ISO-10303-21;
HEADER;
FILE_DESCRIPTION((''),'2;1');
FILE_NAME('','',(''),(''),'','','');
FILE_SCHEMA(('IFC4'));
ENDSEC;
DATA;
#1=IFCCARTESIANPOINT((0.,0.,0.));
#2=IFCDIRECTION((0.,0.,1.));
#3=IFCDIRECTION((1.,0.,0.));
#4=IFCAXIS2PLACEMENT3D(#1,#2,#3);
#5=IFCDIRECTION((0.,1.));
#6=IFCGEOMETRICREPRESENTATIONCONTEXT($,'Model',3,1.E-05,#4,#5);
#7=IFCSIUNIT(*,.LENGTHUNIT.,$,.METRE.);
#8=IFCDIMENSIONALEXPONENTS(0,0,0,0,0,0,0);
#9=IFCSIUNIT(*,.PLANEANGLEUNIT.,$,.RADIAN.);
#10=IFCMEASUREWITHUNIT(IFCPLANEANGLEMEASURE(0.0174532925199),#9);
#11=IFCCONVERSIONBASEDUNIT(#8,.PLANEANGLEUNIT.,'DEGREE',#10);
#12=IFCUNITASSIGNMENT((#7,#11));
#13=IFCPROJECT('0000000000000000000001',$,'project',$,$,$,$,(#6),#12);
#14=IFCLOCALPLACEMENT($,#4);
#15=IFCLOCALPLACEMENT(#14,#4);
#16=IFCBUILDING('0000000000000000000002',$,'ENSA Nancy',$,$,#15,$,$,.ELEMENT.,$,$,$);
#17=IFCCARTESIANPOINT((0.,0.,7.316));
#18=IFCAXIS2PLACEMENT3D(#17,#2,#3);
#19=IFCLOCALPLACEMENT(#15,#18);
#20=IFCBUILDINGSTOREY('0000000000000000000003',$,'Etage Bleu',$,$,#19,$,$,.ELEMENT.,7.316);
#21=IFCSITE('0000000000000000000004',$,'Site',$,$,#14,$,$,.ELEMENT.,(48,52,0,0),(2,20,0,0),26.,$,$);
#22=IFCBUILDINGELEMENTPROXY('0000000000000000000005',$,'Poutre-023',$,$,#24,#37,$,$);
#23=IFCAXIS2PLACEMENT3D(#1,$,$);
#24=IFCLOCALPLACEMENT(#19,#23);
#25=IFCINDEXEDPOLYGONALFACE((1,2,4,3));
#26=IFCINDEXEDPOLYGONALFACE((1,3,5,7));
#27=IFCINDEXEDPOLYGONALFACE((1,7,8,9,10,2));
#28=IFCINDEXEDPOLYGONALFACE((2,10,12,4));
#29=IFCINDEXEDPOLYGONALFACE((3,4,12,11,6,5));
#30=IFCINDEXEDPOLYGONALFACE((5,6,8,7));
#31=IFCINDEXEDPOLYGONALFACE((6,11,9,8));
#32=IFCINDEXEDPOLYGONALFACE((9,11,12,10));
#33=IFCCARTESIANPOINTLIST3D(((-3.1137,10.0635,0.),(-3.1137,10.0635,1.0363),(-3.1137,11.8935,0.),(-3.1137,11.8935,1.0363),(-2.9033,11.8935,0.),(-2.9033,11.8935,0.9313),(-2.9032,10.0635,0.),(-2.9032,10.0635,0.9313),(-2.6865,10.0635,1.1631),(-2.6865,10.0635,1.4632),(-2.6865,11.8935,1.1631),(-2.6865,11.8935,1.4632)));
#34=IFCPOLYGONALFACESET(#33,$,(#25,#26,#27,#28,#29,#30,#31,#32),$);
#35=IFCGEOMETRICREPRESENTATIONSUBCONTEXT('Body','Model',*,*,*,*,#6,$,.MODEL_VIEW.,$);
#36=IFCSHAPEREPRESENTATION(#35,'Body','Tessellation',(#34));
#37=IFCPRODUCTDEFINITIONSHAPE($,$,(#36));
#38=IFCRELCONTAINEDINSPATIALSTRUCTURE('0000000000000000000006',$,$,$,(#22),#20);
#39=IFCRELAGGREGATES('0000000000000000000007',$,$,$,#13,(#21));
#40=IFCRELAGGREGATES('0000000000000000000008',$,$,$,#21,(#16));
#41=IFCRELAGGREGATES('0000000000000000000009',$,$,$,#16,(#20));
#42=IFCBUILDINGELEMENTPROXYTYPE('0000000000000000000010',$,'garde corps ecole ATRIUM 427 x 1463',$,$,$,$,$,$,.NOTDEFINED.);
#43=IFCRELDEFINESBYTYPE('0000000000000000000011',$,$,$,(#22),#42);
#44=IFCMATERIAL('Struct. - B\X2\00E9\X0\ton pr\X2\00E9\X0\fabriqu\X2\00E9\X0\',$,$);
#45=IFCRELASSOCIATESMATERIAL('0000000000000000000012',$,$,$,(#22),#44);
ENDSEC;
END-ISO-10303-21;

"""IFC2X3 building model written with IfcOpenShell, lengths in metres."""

from ifc_helpers import new_model, entity, si_unit, converted_unit, direction, frame, origin_with_axes, place, context, subcontext, project, spatial, polyline, outline, extrude, material, type_object, element, save


model = new_model("IFC2X3")

# Units and contexts
model_context = context("Model", 3, precision=1e-05, world=origin_with_axes(), true_north=direction((0.0, 1.0)))
body_context = subcontext(model_context, "Body", "Model", "MODEL_VIEW")
ifc_project = project(units=[si_unit("LENGTHUNIT", "METRE"), converted_unit("PLANEANGLEUNIT", "DEGREE", entity("IfcPlaneAngleMeasure", 0.0174532925199), si_unit("PLANEANGLEUNIT", "RADIAN"), dimensions=[0, 0, 0, 0, 0, 0, 0])], contexts=[model_context])

# Site, building, storey
site_placement = place(None, origin_with_axes())
site = spatial("IfcSite", under=ifc_project, at=site_placement, Name="Site", CompositionType="ELEMENT", RefLatitude=(48, 52, 0, 0), RefLongitude=(2, 20, 0, 0), RefElevation=26.0)
building_placement = place(site_placement, origin_with_axes())
building = spatial("IfcBuilding", under=site, at=building_placement, Name="ENSA Nancy", CompositionType="ELEMENT")
storey_placement = place(building_placement, frame((0.0, 0.0, 7.316), z_axis=(0.0, 0.0, 1.0), x_axis=(1.0, 0.0, 0.0)))
storey = spatial("IfcBuildingStorey", under=building, at=storey_placement, Name="Etage Bleu", CompositionType="ELEMENT", Elevation=7.316)

# Building element proxy
ifc_material_1 = material(Name="Struct. - Béton préfabriqué")
building_element_proxy_type_1 = type_object("IfcBuildingElementProxyType", Name="garde corps ecole ATRIUM 427 x 1463", PredefinedType="NOTDEFINED")
proxy_1_placement = place(storey_placement, frame((-3.1137, 10.0635, 0.0), z_axis=(0.0, 0.0, 1.0), x_axis=(1.0, 0.000024, 0.0)))
element("IfcBuildingElementProxy", 1, at=proxy_1_placement, inside=storey, type_object=building_element_proxy_type_1, material=ifc_material_1, Name="Poutre-023", context=body_context, shape_type="SweptSolid", body=[
    extrude(outline(polyline([(0.0, 1.0363), (0.0, 0.0), (0.2105, 0.0), (0.2105, 0.9313), (0.4272, 1.1631), (0.4272, 1.4632), (0.0, 1.0363)])), frame((0.0, 1.83, 0.0), z_axis=(0.0, -1.0, 0.0), x_axis=(1.0, 0.0, 0.0)), (0.0, 0.0, 1.0), 1.83),
])

save(model, "model.ifc")
